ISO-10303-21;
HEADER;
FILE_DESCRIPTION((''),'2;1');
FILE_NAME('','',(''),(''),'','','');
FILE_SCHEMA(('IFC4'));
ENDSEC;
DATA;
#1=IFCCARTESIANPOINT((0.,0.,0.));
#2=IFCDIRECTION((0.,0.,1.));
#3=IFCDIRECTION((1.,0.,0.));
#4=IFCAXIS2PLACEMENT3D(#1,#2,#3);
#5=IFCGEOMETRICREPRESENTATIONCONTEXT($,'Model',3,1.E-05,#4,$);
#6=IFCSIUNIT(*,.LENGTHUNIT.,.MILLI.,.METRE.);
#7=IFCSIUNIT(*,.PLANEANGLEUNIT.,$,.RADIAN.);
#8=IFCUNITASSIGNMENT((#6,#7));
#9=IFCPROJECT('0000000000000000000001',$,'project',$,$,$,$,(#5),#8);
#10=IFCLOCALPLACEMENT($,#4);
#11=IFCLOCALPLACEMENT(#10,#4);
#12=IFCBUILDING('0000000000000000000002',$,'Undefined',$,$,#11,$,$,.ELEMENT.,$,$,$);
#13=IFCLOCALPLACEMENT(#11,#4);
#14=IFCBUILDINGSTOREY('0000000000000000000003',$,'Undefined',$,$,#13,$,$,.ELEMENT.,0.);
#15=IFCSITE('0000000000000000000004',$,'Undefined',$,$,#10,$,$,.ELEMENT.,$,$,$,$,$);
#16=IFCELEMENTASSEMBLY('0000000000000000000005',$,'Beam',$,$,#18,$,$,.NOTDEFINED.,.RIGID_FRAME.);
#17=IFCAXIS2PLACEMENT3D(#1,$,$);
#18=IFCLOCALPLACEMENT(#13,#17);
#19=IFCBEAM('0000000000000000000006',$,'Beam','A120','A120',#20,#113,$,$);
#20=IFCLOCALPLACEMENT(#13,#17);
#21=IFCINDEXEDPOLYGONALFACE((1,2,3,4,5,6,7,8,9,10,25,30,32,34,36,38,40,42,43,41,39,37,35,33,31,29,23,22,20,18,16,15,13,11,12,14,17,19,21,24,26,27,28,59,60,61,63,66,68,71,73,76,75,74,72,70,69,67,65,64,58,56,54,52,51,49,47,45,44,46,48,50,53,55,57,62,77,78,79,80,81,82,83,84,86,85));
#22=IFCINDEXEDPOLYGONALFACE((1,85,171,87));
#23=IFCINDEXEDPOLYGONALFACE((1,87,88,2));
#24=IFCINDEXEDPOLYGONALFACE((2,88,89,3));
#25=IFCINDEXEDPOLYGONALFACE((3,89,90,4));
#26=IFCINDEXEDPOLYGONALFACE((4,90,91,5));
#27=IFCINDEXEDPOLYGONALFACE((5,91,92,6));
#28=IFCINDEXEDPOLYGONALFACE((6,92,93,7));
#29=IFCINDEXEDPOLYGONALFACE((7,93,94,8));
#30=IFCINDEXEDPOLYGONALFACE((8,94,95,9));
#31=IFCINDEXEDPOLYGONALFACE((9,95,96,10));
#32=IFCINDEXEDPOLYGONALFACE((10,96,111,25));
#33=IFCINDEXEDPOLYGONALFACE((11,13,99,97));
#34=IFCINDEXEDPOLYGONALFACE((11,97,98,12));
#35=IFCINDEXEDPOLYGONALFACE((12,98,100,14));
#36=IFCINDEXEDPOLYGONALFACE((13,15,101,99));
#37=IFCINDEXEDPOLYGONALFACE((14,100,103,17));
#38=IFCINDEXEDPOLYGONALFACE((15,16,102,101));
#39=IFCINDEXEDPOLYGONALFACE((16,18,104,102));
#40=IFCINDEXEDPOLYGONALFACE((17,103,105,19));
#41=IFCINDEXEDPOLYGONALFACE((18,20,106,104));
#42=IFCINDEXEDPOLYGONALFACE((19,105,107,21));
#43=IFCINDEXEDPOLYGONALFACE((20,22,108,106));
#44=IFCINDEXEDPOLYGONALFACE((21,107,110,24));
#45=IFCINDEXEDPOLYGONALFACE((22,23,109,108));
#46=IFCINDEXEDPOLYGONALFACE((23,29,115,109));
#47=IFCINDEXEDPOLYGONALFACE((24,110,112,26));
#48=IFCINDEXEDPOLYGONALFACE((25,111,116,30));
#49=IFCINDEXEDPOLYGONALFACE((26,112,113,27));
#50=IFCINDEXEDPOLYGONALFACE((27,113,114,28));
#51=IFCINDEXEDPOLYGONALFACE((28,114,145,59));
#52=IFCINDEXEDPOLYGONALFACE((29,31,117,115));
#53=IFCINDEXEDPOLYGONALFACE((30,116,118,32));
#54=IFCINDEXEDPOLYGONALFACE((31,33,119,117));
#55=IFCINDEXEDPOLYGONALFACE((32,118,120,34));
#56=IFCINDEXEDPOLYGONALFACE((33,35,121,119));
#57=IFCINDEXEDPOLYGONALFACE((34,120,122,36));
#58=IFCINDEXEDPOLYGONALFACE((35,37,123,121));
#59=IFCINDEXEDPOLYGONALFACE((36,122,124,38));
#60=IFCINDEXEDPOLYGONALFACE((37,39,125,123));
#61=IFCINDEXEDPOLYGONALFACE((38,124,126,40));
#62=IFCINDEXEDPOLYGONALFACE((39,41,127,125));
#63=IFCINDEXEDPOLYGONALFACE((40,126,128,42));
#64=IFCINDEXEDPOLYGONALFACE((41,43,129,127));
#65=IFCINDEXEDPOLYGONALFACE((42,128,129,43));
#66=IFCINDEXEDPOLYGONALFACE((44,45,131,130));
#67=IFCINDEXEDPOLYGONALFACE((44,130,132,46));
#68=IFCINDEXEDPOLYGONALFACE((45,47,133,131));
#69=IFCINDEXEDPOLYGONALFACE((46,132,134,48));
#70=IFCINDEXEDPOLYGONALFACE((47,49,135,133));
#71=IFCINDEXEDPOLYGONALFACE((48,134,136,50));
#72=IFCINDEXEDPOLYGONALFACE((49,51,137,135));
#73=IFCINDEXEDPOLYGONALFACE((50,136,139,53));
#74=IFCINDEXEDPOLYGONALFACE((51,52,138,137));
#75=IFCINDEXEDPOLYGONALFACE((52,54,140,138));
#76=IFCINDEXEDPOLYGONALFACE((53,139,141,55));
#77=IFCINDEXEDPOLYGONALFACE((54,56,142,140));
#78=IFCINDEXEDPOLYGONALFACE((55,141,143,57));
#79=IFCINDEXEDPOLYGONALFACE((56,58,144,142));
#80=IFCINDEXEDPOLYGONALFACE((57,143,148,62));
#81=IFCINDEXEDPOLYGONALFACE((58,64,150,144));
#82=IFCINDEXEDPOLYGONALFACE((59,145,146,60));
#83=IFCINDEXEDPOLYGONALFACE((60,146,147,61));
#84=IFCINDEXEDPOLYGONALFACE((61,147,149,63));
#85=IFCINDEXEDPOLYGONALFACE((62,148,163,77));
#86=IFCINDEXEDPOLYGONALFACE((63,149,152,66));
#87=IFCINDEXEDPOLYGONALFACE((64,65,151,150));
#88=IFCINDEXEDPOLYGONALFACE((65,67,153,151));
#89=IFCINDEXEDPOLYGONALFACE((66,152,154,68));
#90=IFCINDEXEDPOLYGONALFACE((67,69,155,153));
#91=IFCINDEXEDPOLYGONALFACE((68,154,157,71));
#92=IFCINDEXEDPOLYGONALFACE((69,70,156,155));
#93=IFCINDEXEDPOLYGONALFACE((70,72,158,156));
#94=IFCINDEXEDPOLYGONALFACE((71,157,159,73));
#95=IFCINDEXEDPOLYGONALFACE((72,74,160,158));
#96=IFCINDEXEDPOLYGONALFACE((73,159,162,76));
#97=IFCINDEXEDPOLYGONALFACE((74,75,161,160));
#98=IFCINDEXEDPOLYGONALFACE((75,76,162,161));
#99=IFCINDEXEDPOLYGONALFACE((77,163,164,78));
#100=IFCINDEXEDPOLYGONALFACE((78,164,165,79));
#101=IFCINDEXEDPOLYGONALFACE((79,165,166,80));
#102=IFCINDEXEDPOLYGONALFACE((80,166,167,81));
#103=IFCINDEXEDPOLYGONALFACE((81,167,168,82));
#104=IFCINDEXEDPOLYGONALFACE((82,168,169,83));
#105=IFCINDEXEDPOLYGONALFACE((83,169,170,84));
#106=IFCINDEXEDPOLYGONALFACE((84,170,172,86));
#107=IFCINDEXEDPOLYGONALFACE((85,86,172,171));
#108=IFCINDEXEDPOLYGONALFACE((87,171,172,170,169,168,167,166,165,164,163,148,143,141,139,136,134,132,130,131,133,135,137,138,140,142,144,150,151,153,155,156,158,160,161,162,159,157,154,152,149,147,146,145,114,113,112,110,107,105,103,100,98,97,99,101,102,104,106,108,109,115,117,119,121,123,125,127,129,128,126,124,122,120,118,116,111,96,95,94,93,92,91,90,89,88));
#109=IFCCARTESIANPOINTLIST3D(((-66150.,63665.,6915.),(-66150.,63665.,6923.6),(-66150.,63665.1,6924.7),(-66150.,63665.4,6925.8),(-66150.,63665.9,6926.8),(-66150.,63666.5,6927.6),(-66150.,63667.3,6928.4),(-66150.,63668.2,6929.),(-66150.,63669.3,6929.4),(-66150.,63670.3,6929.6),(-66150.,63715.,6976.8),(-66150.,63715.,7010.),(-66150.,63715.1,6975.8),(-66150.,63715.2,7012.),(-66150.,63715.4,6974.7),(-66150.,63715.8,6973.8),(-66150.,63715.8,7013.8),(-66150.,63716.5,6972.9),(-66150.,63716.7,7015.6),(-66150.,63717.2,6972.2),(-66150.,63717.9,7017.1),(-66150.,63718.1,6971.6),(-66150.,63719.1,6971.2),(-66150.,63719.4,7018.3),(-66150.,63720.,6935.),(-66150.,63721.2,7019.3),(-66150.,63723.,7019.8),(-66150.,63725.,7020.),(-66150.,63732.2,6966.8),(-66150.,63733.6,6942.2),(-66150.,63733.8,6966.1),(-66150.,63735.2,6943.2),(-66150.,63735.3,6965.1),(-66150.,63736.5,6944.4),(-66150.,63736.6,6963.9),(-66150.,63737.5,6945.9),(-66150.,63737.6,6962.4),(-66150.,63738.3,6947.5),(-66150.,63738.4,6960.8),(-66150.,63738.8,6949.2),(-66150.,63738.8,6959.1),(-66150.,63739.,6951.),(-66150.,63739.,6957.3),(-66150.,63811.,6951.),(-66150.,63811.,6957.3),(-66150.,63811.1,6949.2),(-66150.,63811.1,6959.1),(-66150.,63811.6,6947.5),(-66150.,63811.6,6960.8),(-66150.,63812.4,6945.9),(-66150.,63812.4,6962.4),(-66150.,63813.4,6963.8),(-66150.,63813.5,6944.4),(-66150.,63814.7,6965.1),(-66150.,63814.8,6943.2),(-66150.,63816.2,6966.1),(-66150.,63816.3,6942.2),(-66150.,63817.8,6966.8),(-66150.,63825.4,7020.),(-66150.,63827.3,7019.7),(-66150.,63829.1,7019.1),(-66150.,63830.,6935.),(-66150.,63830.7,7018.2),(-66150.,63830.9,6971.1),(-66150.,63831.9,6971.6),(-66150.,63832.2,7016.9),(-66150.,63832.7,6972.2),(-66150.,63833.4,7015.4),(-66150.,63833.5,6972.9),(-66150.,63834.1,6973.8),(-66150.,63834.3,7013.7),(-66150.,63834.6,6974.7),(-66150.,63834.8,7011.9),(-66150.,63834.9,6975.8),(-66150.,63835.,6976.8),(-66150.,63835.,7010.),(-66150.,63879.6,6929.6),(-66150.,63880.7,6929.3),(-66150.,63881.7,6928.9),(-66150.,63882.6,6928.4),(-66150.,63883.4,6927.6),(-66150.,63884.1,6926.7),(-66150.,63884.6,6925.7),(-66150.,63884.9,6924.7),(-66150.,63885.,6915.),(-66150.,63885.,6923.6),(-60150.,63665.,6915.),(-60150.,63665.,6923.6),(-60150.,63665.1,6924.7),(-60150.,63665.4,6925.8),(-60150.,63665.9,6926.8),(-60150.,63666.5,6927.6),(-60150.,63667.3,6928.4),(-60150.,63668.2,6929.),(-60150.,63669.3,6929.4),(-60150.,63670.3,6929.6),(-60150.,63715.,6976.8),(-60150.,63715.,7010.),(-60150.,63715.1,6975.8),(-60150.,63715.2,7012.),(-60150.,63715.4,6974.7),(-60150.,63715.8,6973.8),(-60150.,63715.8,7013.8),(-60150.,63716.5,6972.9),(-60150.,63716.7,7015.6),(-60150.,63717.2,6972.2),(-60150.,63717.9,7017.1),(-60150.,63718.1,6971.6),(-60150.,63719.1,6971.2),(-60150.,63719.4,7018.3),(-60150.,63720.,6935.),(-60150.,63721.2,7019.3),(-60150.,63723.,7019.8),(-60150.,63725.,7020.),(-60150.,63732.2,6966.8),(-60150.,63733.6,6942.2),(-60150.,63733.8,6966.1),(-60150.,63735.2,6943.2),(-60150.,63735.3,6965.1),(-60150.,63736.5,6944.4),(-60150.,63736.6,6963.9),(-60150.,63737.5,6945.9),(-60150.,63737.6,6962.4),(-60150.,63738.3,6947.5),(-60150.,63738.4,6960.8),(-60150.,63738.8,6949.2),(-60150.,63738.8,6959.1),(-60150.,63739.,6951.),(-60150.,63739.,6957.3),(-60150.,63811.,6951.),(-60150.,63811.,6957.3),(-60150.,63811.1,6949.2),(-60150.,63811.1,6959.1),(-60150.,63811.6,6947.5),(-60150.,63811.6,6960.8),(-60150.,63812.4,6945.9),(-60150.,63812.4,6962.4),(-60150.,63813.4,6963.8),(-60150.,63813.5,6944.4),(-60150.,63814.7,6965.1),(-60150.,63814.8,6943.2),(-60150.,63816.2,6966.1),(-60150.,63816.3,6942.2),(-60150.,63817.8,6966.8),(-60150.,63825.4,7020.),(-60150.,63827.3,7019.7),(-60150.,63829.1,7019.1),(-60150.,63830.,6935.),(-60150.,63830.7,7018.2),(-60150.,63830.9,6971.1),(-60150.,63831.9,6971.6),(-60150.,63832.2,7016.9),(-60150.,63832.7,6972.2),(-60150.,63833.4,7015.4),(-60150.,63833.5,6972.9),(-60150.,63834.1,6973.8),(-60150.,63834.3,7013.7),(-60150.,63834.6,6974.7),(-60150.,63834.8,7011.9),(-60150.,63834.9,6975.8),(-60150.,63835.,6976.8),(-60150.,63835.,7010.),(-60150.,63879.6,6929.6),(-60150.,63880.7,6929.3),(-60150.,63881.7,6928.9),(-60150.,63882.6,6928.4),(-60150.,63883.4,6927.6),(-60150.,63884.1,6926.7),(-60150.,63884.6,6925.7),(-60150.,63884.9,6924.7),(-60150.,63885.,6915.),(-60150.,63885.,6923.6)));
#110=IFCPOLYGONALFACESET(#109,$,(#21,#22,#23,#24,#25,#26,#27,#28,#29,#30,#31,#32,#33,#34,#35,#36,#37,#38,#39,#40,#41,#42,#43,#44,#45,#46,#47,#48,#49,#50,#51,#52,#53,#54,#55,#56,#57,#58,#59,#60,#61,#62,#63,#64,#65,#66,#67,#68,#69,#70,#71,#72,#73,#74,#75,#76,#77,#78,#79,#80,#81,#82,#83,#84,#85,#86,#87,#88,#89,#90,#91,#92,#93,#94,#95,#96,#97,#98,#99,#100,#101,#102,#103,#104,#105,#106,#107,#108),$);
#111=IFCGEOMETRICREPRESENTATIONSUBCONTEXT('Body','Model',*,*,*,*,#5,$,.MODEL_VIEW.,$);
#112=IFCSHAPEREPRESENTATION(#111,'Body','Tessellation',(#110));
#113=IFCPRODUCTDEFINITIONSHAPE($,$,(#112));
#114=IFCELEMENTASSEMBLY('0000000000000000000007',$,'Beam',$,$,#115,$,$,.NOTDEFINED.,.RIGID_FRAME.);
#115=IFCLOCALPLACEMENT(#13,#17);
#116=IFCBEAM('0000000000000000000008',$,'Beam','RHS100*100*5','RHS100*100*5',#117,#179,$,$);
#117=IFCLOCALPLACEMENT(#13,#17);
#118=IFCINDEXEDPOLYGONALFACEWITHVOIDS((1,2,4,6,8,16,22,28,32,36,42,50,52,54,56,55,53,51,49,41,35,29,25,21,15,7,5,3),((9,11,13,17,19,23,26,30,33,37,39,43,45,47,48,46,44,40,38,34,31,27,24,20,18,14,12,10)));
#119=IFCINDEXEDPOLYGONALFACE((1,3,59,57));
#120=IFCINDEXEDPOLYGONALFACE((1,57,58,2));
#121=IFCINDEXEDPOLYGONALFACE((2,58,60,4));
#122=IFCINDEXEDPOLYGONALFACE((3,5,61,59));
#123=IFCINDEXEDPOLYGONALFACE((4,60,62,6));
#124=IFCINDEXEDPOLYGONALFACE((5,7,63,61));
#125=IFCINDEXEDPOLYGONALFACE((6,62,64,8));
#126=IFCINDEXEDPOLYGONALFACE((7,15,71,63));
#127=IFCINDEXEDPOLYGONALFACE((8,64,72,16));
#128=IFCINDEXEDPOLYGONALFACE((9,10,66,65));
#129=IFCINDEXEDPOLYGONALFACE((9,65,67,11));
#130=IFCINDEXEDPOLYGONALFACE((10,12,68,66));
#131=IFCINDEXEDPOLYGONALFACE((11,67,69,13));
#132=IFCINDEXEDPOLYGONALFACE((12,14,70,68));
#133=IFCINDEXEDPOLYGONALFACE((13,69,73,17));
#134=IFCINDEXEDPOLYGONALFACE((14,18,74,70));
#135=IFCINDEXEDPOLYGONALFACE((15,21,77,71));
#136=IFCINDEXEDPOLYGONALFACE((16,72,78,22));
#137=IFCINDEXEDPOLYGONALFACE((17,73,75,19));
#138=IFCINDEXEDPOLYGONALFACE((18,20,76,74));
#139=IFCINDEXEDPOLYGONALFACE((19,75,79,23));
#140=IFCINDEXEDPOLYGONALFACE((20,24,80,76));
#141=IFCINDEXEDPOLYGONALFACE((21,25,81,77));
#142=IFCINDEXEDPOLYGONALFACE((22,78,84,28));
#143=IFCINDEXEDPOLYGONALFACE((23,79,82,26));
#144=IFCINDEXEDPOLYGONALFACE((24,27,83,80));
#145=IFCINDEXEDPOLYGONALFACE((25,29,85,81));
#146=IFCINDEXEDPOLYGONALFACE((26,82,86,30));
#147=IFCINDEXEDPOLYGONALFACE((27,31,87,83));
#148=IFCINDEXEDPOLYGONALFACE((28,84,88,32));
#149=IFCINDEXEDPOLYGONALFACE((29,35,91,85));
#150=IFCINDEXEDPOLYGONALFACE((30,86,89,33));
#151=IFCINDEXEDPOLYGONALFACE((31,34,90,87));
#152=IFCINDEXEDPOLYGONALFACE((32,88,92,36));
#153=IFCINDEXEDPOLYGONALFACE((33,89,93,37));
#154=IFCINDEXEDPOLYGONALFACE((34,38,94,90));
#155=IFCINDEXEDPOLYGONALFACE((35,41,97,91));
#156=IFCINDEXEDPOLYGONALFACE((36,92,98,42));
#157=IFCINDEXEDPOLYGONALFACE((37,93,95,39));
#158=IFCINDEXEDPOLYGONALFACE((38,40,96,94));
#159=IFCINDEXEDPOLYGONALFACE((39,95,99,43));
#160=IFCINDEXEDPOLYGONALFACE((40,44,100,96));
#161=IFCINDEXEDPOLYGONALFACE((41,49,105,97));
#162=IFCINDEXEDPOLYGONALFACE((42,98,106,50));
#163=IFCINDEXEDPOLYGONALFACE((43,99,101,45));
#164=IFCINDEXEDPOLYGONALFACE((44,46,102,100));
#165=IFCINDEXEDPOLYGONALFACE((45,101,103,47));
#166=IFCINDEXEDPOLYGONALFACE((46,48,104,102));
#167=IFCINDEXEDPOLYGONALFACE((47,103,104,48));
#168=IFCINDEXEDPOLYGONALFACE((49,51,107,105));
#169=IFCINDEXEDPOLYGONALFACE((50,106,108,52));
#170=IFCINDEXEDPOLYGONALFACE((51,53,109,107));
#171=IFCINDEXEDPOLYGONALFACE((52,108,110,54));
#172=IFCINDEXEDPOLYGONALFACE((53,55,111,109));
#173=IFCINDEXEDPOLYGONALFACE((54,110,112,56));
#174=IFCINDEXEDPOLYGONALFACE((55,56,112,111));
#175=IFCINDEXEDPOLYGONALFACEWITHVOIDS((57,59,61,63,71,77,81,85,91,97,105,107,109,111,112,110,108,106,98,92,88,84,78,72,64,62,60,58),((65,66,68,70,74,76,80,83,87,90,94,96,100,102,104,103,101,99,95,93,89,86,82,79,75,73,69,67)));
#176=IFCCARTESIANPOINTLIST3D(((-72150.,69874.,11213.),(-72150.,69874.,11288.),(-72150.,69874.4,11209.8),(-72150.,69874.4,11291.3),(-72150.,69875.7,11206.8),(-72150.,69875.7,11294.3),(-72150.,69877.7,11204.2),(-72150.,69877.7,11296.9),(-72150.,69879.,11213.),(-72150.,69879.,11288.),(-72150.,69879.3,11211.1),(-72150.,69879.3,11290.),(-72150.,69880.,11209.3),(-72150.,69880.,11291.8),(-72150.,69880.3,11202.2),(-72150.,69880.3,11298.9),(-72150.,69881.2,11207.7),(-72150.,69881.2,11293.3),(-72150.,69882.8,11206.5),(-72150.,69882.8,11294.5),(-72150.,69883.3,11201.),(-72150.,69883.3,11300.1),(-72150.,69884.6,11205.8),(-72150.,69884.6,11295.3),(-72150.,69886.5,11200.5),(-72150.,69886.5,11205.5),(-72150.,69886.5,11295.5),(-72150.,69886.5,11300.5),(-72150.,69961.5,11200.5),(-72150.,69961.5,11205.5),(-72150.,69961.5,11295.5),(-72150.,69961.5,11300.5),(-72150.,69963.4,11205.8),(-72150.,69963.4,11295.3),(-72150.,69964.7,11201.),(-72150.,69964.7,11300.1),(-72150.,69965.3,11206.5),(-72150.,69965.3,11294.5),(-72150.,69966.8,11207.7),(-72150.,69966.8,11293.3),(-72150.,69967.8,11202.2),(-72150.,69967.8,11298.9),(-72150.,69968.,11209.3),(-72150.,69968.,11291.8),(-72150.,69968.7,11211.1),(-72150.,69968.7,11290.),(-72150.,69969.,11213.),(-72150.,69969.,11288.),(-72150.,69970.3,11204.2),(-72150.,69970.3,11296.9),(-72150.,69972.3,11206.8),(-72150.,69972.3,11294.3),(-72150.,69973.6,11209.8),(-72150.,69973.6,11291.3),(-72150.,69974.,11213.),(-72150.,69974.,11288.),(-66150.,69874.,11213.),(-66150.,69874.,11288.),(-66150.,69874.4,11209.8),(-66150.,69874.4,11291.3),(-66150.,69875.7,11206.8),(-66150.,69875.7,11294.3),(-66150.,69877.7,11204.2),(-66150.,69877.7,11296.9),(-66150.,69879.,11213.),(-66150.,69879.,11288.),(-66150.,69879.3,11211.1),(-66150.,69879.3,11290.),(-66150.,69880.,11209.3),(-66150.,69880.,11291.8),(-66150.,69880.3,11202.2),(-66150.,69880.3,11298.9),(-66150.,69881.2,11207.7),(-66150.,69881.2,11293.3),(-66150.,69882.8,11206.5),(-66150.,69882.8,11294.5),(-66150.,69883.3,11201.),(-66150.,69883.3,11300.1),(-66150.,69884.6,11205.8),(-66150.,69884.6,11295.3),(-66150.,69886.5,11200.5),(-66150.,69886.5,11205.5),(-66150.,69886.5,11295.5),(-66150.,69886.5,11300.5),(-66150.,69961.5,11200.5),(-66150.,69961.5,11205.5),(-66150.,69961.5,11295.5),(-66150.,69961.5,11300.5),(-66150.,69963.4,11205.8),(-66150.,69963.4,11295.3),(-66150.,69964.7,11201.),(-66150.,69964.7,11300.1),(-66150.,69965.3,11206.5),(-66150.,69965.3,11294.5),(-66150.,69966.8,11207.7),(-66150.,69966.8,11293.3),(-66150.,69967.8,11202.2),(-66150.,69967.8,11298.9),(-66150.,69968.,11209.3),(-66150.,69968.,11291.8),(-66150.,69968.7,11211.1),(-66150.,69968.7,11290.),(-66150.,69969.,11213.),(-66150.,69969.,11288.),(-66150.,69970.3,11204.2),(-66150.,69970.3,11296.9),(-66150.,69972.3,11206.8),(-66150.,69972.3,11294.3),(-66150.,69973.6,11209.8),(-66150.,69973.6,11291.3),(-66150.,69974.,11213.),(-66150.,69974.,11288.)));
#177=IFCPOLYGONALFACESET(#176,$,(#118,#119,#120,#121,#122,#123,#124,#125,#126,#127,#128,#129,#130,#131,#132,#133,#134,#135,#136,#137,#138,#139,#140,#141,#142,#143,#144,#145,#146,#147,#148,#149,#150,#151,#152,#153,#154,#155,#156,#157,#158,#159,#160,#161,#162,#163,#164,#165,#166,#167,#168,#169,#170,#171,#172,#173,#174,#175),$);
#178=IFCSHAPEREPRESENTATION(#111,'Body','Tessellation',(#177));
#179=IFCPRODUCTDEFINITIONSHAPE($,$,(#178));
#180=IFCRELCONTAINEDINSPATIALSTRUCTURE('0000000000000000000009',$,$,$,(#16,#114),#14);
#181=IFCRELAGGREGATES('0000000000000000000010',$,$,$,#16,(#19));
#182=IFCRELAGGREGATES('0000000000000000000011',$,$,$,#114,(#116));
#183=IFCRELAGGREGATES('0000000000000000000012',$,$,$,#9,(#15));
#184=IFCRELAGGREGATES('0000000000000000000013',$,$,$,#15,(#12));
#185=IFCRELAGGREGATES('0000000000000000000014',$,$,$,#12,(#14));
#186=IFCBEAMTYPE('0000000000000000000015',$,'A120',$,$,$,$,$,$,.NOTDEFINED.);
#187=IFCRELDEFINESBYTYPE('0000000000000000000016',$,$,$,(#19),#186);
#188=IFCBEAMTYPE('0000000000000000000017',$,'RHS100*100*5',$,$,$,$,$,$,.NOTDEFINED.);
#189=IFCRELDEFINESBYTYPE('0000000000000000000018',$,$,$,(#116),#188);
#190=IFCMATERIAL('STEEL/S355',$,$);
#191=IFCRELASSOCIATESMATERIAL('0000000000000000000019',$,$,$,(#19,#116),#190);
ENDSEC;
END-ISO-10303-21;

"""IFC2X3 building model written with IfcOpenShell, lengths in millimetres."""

from ifc_helpers import new_model, si_unit, frame, origin_with_axes, origin_2d_with_axis, place, context, subcontext, project, spatial, polyline, hollow_rectangle, outline, extrude, material, type_object, element, aggregate, save


model = new_model("IFC2X3")

# Units and contexts
model_context = context("Model", 3, precision=1e-05, world=origin_with_axes())
body_context = subcontext(model_context, "Body", "Model", "MODEL_VIEW")
ifc_project = project(units=[si_unit("LENGTHUNIT", "METRE", prefix="MILLI"), si_unit("PLANEANGLEUNIT", "RADIAN")], contexts=[model_context])

# Site, building, storey
site_placement = place(None, origin_with_axes())
site = spatial("IfcSite", under=ifc_project, at=site_placement, Name="Undefined", CompositionType="ELEMENT")
building_placement = place(site_placement, origin_with_axes())
building = spatial("IfcBuilding", under=site, at=building_placement, Name="Undefined", CompositionType="ELEMENT")
storey_placement = place(building_placement, origin_with_axes())
storey = spatial("IfcBuildingStorey", under=building, at=storey_placement, Name="Undefined", CompositionType="ELEMENT", Elevation=0.0)

# Element assemblies, beams
assembly_1_placement = place(storey_placement, origin_with_axes())
assembly_1 = element("IfcElementAssembly", 1, at=assembly_1_placement, inside=storey, Name="Beam", AssemblyPlace="NOTDEFINED", PredefinedType="RIGID_FRAME")
ifc_material = material(Name="STEEL/S355")
beam_type_1 = type_object("IfcBeamType", Name="A120", PredefinedType="NOTDEFINED")
beam_1_placement = place(assembly_1_placement, frame((-66150.0, 63775.0, 6967.5), z_axis=(0.0, 0.000118, 1.0), x_axis=(1.0, 0.0, 0.0)))
beam_1 = element("IfcBeam", 2, at=beam_1_placement, type_object=beam_type_1, material=ifc_material, Name="Beam", Description="A120", ObjectType="A120", context=body_context, shape_type="SweptSolid", body=[
    extrude(outline(polyline([(-110.0, -52.5), (-110.0, -43.9), (-109.9, -42.8), (-109.6, -41.8), (-109.1, -40.8), (-108.5, -39.9), (-107.7, -39.1), (-106.7, -38.6), (-105.7, -38.2), (-104.7, -37.9), (-55.0, -32.5), (-41.3, -25.3), (-39.8, -24.3), (-38.5, -23.1), (-37.4, -21.6), (-36.6, -20.0), (-36.2, -18.3), (-36.0, -16.5), (-36.0, -10.2), (-36.1, -8.4), (-36.6, -6.7), (-37.4, -5.1), (-38.4, -3.7), (-39.7, -2.4), (-41.2, -1.4), (-42.8, -0.7), (-55.9, 3.6), (-56.9, 4.1), (-57.8, 4.7), (-58.5, 5.4), (-59.2, 6.3), (-59.6, 7.2), (-59.9, 8.3), (-60.0, 9.3), (-60.0, 42.5), (-59.8, 44.4), (-59.3, 46.2), (-58.4, 47.9), (-57.2, 49.4), (-55.7, 50.7), (-54.1, 51.6), (-52.3, 52.2), (-50.4, 52.5), (50.0, 52.5), (51.9, 52.3), (53.8, 51.7), (55.5, 50.8), (57.1, 49.6), (58.3, 48.1), (59.2, 46.3), (59.8, 44.4), (60.0, 42.5), (60.0, 9.3), (59.9, 8.3), (59.6, 7.2), (59.2, 6.3), (58.5, 5.4), (57.8, 4.7), (56.9, 4.1), (55.9, 3.6), (42.8, -0.7), (41.2, -1.4), (39.7, -2.4), (38.4, -3.7), (37.4, -5.1), (36.6, -6.7), (36.1, -8.4), (36.0, -10.2), (36.0, -16.5), (36.2, -18.3), (36.6, -20.0), (37.4, -21.6), (38.5, -23.1), (39.8, -24.3), (41.3, -25.3), (55.0, -32.5), (104.7, -37.9), (105.7, -38.2), (106.7, -38.6), (107.7, -39.1), (108.5, -39.9), (109.1, -40.8), (109.6, -41.8), (109.9, -42.8), (110.0, -43.9), (110.0, -52.5), (-110.0, -52.5)])), frame((6000.0, 0.0, 0.0), z_axis=(-1.0, 0.0, 0.0), x_axis=(0.0, -1.0, 0.0)), (0.0, 0.0, 1.0), 6000.0),
])
aggregate(assembly_1, [beam_1])
assembly_2_placement = place(storey_placement, origin_with_axes())
assembly_2 = element("IfcElementAssembly", 3, at=assembly_2_placement, inside=storey, Name="Beam", AssemblyPlace="NOTDEFINED", PredefinedType="RIGID_FRAME")
beam_type_2 = type_object("IfcBeamType", Name="RHS100*100*5", PredefinedType="NOTDEFINED")
beam_2_placement = place(assembly_2_placement, frame((-66150.0, 69924.0, 11250.5), z_axis=(0.0, 0.0, 1.0), x_axis=(-1.0, 0.0, 0.0)))
beam_2 = element("IfcBeam", 4, at=beam_2_placement, type_object=beam_type_2, material=ifc_material, Name="Beam", Description="RHS100*100*5", ObjectType="RHS100*100*5", context=body_context, shape_type="SweptSolid", body=[
    extrude(hollow_rectangle(XDim=100.0, YDim=100.0, WallThickness=5.0, InnerFilletRadius=7.5, OuterFilletRadius=12.5, at=origin_2d_with_axis()), frame((6000.0, 0.0, 0.0), z_axis=(-1.0, 0.0, 0.0), x_axis=(0.0, -1.0, 0.0)), (0.0, 0.0, 1.0), 6000.0),
])
aggregate(assembly_2, [beam_2])

save(model, "model.ifc")
